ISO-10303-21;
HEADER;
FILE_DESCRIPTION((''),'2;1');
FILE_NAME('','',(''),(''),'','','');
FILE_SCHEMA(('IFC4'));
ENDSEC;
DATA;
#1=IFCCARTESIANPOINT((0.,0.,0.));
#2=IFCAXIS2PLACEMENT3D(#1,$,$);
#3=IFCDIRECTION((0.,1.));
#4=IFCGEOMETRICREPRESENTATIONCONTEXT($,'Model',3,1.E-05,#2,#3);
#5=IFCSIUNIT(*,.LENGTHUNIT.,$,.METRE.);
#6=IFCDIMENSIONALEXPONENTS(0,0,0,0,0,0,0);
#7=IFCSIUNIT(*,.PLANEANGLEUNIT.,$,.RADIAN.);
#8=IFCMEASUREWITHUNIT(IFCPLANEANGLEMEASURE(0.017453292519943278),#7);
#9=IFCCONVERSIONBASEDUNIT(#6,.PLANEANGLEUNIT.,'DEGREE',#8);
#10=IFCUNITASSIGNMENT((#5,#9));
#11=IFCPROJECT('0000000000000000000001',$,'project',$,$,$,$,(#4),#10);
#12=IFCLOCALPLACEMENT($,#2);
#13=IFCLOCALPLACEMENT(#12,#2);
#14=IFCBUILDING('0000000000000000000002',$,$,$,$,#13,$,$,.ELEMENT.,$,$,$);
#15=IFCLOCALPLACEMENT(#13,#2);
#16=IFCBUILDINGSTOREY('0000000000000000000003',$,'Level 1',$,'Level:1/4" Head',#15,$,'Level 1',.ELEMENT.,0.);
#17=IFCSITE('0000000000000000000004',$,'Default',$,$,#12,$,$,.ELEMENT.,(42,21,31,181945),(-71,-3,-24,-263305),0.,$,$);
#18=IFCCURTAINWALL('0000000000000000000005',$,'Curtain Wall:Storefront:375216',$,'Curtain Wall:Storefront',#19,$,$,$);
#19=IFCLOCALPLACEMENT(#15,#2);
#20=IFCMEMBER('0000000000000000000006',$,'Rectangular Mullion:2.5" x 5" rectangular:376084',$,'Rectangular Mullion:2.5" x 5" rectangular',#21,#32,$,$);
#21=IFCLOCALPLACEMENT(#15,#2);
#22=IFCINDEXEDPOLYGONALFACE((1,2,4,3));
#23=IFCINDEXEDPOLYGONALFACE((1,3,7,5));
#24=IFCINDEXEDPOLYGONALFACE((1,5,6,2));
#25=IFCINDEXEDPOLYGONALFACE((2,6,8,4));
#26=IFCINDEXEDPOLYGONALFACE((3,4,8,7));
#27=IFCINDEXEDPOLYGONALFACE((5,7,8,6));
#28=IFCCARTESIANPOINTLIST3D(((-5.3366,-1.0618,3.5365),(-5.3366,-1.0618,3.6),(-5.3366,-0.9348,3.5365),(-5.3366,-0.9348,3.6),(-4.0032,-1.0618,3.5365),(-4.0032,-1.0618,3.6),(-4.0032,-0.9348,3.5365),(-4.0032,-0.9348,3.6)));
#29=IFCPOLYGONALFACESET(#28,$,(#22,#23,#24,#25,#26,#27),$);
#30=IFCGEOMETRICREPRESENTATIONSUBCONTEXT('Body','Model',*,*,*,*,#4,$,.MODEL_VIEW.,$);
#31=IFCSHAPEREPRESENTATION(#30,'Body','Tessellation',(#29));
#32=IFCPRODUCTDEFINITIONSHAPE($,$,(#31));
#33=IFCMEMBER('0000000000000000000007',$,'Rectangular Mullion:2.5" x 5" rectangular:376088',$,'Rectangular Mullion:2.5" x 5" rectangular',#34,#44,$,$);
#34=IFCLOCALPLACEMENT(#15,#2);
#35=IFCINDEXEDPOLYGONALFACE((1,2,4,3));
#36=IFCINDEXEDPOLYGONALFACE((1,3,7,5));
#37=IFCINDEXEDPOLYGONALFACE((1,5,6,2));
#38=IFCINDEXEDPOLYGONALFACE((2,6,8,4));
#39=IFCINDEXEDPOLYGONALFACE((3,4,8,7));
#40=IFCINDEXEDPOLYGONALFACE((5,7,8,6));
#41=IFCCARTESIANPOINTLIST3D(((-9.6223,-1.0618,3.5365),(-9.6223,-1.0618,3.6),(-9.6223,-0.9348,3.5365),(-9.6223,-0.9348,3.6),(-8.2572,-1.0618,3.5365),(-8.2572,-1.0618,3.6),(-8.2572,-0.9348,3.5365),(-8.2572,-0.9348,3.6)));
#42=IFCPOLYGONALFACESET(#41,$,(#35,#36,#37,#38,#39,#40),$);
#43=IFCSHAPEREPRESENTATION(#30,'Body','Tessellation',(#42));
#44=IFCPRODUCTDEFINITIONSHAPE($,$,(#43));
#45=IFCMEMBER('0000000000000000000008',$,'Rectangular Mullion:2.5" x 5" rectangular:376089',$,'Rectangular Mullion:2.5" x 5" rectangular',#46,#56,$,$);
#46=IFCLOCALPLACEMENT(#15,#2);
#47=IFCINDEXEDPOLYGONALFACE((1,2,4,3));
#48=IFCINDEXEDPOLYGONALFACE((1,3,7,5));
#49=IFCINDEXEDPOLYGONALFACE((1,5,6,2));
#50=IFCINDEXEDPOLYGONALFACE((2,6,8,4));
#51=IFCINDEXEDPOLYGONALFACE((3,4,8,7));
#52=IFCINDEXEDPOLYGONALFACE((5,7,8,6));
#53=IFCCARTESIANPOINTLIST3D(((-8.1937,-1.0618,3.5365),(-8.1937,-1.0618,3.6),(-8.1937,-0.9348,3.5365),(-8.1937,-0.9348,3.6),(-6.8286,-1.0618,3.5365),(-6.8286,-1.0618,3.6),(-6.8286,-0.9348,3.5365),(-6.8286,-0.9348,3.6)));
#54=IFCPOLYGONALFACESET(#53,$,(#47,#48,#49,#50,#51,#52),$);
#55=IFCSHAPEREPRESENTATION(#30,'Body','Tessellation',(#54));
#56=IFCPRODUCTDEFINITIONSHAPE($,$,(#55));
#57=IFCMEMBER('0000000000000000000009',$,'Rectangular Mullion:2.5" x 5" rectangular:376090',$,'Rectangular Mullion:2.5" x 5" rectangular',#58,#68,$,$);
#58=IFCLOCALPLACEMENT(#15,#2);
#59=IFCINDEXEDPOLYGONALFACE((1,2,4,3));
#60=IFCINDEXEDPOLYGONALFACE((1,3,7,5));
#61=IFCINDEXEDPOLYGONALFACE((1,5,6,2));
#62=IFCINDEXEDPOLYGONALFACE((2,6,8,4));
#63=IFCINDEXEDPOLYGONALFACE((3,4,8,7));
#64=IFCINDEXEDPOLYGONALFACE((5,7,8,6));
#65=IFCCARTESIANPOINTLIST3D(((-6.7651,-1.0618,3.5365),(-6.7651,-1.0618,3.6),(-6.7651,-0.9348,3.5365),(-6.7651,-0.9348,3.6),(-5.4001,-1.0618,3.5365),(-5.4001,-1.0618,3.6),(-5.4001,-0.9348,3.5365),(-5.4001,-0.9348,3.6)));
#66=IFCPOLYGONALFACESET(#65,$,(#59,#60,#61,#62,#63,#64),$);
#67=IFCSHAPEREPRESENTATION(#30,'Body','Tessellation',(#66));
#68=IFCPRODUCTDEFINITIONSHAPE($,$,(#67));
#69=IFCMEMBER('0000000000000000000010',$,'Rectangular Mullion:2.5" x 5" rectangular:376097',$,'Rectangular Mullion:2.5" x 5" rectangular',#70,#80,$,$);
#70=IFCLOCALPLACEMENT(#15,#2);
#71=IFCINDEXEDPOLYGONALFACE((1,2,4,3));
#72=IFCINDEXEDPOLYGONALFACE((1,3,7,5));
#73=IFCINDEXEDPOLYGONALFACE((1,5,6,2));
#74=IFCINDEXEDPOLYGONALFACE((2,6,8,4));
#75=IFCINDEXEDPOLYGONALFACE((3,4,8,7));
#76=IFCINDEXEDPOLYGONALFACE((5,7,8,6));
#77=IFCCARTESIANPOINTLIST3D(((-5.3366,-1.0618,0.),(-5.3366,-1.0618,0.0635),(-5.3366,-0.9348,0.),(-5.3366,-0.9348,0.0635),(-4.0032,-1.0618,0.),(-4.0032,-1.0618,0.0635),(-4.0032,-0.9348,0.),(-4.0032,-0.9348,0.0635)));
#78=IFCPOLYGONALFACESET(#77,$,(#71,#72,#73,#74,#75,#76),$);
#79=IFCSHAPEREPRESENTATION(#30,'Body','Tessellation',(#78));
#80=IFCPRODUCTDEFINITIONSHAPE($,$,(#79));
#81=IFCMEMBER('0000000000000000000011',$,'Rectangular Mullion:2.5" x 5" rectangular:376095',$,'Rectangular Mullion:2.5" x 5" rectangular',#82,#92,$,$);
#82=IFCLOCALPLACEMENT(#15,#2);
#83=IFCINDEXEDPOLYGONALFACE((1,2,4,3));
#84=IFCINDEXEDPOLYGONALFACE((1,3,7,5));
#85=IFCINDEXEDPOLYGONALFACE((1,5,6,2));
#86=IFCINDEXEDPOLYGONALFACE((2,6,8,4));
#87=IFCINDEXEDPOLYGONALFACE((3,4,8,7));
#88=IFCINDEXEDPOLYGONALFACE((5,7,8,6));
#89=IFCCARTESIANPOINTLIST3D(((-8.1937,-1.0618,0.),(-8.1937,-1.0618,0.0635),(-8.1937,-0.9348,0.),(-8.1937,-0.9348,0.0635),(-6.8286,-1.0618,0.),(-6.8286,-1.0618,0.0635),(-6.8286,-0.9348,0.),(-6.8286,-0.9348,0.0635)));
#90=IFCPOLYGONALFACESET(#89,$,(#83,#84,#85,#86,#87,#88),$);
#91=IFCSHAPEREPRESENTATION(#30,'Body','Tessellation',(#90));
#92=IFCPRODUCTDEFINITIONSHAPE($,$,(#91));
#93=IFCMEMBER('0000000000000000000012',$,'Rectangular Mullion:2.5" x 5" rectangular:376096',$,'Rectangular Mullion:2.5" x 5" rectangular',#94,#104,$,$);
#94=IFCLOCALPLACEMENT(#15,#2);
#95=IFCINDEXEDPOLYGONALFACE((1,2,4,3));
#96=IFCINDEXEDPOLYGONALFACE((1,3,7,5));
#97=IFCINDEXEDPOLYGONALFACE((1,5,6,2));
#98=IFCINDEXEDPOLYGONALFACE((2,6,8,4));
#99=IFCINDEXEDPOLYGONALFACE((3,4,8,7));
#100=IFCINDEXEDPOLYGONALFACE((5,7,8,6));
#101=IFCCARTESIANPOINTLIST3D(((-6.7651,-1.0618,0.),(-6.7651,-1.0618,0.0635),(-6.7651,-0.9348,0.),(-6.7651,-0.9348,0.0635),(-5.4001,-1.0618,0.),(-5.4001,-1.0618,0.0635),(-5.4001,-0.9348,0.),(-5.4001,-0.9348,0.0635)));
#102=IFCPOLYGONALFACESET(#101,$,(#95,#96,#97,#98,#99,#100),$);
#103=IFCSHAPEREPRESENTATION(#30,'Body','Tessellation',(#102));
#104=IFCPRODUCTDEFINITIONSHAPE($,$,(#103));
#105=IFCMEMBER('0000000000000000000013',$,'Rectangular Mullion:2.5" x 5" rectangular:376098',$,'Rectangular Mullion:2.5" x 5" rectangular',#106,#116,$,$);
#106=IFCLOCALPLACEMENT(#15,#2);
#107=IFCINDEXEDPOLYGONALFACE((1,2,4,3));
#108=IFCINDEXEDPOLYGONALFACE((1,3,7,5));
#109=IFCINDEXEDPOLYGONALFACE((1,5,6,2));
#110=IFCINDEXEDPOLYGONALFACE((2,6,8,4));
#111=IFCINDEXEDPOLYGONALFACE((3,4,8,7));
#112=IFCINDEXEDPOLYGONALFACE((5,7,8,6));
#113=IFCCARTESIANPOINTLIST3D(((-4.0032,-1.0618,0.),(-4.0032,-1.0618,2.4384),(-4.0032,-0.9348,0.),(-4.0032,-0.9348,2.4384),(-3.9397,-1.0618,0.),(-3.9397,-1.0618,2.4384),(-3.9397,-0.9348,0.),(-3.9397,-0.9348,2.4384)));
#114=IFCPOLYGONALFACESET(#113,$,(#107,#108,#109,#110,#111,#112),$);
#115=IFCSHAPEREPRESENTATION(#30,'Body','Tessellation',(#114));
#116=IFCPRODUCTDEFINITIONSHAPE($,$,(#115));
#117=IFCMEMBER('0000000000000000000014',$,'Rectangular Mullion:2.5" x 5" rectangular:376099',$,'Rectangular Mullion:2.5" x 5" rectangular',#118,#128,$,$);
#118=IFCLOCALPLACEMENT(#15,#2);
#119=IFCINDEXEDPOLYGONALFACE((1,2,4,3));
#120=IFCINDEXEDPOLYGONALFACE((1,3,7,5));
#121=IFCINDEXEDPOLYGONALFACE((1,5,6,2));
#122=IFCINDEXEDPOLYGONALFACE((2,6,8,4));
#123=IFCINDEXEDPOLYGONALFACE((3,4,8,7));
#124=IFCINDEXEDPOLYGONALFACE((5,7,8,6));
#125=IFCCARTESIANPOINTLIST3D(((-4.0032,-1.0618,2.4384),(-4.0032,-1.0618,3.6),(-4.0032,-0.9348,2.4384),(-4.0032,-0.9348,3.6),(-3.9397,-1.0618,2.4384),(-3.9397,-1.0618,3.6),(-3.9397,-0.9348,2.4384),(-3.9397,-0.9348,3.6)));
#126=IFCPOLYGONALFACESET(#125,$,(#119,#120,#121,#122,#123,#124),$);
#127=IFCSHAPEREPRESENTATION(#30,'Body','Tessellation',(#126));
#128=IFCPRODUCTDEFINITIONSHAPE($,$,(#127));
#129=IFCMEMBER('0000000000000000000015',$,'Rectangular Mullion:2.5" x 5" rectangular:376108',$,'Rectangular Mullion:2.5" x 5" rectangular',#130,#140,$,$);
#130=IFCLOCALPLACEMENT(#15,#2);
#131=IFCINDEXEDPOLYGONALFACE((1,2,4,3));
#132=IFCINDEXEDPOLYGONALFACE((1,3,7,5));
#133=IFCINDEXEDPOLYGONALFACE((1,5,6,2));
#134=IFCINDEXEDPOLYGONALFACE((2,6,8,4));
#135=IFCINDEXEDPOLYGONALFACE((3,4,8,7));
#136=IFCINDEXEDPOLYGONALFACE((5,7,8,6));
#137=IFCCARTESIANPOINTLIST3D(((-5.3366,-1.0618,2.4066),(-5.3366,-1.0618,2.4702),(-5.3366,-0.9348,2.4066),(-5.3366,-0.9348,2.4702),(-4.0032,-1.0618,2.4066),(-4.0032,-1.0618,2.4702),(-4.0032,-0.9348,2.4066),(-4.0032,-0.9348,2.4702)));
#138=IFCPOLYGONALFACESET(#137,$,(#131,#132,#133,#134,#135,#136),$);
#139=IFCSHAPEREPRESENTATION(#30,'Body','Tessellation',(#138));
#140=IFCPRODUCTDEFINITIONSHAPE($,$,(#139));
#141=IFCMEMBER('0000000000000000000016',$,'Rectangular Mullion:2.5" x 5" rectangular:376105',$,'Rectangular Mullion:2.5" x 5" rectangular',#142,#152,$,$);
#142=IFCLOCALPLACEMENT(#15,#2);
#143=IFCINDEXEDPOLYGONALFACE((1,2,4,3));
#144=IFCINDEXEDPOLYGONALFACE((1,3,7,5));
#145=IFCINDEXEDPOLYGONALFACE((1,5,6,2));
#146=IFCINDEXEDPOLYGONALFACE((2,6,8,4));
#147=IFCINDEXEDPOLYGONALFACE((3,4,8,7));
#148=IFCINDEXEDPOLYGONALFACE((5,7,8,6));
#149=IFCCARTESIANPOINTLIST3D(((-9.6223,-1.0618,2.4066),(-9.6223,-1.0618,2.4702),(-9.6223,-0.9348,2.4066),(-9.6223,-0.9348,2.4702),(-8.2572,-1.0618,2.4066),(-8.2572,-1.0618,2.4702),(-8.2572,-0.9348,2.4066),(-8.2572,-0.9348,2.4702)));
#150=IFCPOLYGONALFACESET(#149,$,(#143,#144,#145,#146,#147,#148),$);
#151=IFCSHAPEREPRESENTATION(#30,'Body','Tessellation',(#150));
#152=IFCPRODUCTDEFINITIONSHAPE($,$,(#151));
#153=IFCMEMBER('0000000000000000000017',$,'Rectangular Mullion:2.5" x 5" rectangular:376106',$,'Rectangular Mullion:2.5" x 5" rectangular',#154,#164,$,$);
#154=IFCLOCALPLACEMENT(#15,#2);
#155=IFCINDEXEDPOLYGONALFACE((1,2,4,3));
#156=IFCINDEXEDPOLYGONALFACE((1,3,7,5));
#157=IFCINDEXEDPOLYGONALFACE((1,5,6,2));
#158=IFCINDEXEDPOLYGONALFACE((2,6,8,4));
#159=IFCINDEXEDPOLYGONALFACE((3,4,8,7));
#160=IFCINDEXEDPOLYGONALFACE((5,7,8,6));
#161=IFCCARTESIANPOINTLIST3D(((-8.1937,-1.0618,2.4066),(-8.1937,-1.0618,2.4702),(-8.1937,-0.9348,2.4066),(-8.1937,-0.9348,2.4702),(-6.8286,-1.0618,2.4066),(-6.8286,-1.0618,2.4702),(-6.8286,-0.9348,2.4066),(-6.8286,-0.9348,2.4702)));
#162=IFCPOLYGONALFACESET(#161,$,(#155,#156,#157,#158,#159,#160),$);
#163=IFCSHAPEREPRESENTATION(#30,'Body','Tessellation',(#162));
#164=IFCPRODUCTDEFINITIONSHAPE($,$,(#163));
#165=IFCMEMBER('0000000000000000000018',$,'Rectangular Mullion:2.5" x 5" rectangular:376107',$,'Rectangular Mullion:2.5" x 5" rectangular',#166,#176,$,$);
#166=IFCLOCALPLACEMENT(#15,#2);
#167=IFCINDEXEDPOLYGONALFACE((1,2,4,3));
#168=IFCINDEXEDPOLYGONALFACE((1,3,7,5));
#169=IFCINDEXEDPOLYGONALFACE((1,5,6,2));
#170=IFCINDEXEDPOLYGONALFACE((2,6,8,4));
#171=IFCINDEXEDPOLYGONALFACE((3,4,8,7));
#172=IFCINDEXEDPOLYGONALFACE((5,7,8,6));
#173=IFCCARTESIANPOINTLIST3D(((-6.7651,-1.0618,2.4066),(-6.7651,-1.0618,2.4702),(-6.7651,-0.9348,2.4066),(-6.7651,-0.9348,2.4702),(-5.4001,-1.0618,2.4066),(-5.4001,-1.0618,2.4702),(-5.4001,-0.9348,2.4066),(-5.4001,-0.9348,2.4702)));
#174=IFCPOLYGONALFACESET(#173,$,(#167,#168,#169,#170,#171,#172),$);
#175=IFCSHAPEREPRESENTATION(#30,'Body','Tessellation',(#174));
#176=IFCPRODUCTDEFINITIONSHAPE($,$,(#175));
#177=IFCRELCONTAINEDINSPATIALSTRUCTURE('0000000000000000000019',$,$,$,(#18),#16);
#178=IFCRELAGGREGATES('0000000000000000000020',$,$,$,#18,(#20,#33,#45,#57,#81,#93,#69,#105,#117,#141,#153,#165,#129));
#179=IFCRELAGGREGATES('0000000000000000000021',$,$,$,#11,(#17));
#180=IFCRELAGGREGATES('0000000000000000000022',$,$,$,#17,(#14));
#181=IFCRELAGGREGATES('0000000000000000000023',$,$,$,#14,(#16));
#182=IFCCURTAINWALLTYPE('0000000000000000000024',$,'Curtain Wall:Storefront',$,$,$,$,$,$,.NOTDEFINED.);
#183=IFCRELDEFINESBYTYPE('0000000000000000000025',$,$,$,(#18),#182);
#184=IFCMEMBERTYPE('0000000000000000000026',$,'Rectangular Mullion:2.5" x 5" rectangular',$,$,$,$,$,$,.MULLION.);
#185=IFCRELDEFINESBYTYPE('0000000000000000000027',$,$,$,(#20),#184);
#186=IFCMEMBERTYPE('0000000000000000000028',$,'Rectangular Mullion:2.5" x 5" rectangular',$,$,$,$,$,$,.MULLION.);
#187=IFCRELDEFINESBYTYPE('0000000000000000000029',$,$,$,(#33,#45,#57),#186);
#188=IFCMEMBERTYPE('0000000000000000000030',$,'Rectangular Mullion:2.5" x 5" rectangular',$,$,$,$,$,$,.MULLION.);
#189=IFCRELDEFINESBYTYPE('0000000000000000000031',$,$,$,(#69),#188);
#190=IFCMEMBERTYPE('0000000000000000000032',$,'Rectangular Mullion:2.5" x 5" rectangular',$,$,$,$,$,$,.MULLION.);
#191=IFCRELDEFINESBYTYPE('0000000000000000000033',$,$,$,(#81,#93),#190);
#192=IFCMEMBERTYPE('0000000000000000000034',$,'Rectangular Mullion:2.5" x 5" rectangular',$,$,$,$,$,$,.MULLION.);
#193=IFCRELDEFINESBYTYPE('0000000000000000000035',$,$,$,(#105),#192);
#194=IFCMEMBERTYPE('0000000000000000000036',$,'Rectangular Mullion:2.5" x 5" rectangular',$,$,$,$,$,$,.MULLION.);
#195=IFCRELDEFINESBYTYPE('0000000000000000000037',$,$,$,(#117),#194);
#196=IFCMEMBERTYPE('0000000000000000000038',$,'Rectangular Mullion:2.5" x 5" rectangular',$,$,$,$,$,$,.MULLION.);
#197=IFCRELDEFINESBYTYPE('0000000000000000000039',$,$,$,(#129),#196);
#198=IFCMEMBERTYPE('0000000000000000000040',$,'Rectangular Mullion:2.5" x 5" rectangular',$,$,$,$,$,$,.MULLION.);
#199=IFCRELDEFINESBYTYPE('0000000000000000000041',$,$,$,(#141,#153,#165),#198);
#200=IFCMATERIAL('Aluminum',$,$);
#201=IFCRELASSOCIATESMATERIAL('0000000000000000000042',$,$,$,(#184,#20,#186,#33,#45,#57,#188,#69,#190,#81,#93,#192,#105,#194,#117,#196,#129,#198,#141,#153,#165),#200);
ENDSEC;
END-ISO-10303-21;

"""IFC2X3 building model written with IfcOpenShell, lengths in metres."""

from ifc_helpers import new_model, entity, si_unit, converted_unit, direction, frame, frame_2d, origin, origin_2d_with_axis, place, context, subcontext, project, spatial, rectangle, extrude, source, transform, mapped, material, type_object, type_shapes, element, aggregate, save


model = new_model("IFC2X3")

# Units and contexts
model_context = context("Model", 3, precision=1e-05, world=origin(), true_north=direction((0.0, 1.0)))
body_context = subcontext(model_context, "Body", "Model", "MODEL_VIEW")
ifc_project = project(units=[si_unit("LENGTHUNIT", "METRE"), converted_unit("PLANEANGLEUNIT", "DEGREE", entity("IfcPlaneAngleMeasure", 0.017453292519943278), si_unit("PLANEANGLEUNIT", "RADIAN"), dimensions=[0, 0, 0, 0, 0, 0, 0])], contexts=[model_context])

# Site, building, storey
site_placement = place(None, origin())
site = spatial("IfcSite", under=ifc_project, at=site_placement, Name="Default", CompositionType="ELEMENT", RefLatitude=(42, 21, 31, 181945), RefLongitude=(-71, -3, -24, -263305), RefElevation=0.0)
building_placement = place(site_placement, origin())
building = spatial("IfcBuilding", under=site, at=building_placement, CompositionType="ELEMENT")
storey_placement = place(building_placement, origin())
storey = spatial("IfcBuildingStorey", under=building, at=storey_placement, Name="Level 1", ObjectType="Level:1/4\" Head", LongName="Level 1", CompositionType="ELEMENT", Elevation=0.0)

# Curtain wall, members
curtain_wall_type = type_object("IfcCurtainWallType", Name="Curtain Wall:Storefront", PredefinedType="NOTDEFINED")
curtain_wall_placement = place(storey_placement, origin())
curtain_wall = element("IfcCurtainWall", 1, at=curtain_wall_placement, inside=storey, type_object=curtain_wall_type, Name="Curtain Wall:Storefront:375216", ObjectType="Curtain Wall:Storefront")
ifc_material_1 = material(Name="Aluminum")
member_type_1 = type_object("IfcMemberType", Name="Rectangular Mullion:2.5\" x 5\" rectangular", PredefinedType="MULLION", material=ifc_material_1)
shared_shape_1 = source(origin(), body_context, "Body", "SweptSolid", [
    extrude(rectangle(XDim=0.0635, YDim=0.127, at=frame_2d((0.0, 0.0), x_axis=(1.0, 0.0))), frame((-0.0318, 0.0, -1.3333), z_axis=(0.0, 0.0, 1.0), x_axis=(-1.0, 0.0, 0.0)), (0.0, 0.0, 1.0), 1.3333),
])
type_shapes(member_type_1, [shared_shape_1])
member_1_placement = place(curtain_wall_placement, frame((-4.0032, -0.9983, 3.6), z_axis=(1.0, 0.0, 0.0), x_axis=(0.0, 0.0, 1.0)))
member_1 = element("IfcMember", 2, at=member_1_placement, type_object=member_type_1, material=ifc_material_1, Name="Rectangular Mullion:2.5\" x 5\" rectangular:376084", ObjectType="Rectangular Mullion:2.5\" x 5\" rectangular", context=body_context, shape_type="MappedRepresentation", body=[
    mapped(shared_shape_1, transform((0.0, 0.0, 0.0), scale=1.0)),
])
member_type_2 = type_object("IfcMemberType", Name="Rectangular Mullion:2.5\" x 5\" rectangular", PredefinedType="MULLION", material=ifc_material_1)
shared_shape_2 = source(origin(), body_context, "Body", "SweptSolid", [
    extrude(rectangle(XDim=0.0635, YDim=0.127, at=frame_2d((0.0, 0.0), x_axis=(1.0, 0.0))), frame((-0.0318, 0.0, -1.3651), z_axis=(0.0, 0.0, 1.0), x_axis=(-1.0, 0.0, 0.0)), (0.0, 0.0, 1.0), 1.3651),
])
type_shapes(member_type_2, [shared_shape_2])
member_2_placement = place(curtain_wall_placement, frame((-8.2572, -0.9983, 3.6), z_axis=(1.0, 0.0, 0.0), x_axis=(0.0, 0.0, 1.0)))
member_2 = element("IfcMember", 3, at=member_2_placement, type_object=member_type_2, material=ifc_material_1, Name="Rectangular Mullion:2.5\" x 5\" rectangular:376088", ObjectType="Rectangular Mullion:2.5\" x 5\" rectangular", context=body_context, shape_type="MappedRepresentation", body=[
    mapped(shared_shape_2, transform((0.0, 0.0, 0.0), scale=1.0)),
])
member_3_placement = place(curtain_wall_placement, frame((-6.8286, -0.9983, 3.6), z_axis=(1.0, 0.0, 0.0), x_axis=(0.0, 0.0, 1.0)))
member_3 = element("IfcMember", 4, at=member_3_placement, type_object=member_type_2, material=ifc_material_1, Name="Rectangular Mullion:2.5\" x 5\" rectangular:376089", ObjectType="Rectangular Mullion:2.5\" x 5\" rectangular", context=body_context, shape_type="MappedRepresentation", body=[
    mapped(shared_shape_2, transform((0.0, 0.0, 0.0), scale=1.0)),
])
member_4_placement = place(curtain_wall_placement, frame((-5.4001, -0.9983, 3.6), z_axis=(1.0, 0.0, 0.0), x_axis=(0.0, 0.0, 1.0)))
member_4 = element("IfcMember", 5, at=member_4_placement, type_object=member_type_2, material=ifc_material_1, Name="Rectangular Mullion:2.5\" x 5\" rectangular:376090", ObjectType="Rectangular Mullion:2.5\" x 5\" rectangular", context=body_context, shape_type="MappedRepresentation", body=[
    mapped(shared_shape_2, transform((0.0, 0.0, 0.0), scale=1.0)),
])
member_type_3 = type_object("IfcMemberType", Name="Rectangular Mullion:2.5\" x 5\" rectangular", PredefinedType="MULLION", material=ifc_material_1)
shared_shape_3 = source(origin(), body_context, "Body", "SweptSolid", [
    extrude(rectangle(XDim=0.0635, YDim=0.127, at=frame_2d((0.0, 0.0), x_axis=(1.0, 0.0))), frame((-0.0318, 0.0, -1.3333), z_axis=(0.0, 0.0, 1.0), x_axis=(-1.0, 0.0, 0.0)), (0.0, 0.0, 1.0), 1.3333),
])
type_shapes(member_type_3, [shared_shape_3])
member_5_placement = place(curtain_wall_placement, frame((-5.3366, -0.9983, 0.0), z_axis=(-1.0, 0.0, 0.0), x_axis=(0.0, 0.0, -1.0)))
member_5 = element("IfcMember", 6, at=member_5_placement, type_object=member_type_3, material=ifc_material_1, Name="Rectangular Mullion:2.5\" x 5\" rectangular:376097", ObjectType="Rectangular Mullion:2.5\" x 5\" rectangular", context=body_context, shape_type="MappedRepresentation", body=[
    mapped(shared_shape_3, transform((0.0, 0.0, 0.0), scale=1.0)),
])
member_type_4 = type_object("IfcMemberType", Name="Rectangular Mullion:2.5\" x 5\" rectangular", PredefinedType="MULLION", material=ifc_material_1)
shared_shape_4 = source(origin(), body_context, "Body", "SweptSolid", [
    extrude(rectangle(XDim=0.0635, YDim=0.127, at=frame_2d((0.0, 0.0), x_axis=(1.0, 0.0))), frame((-0.0318, 0.0, -1.3651), z_axis=(0.0, 0.0, 1.0), x_axis=(-1.0, 0.0, 0.0)), (0.0, 0.0, 1.0), 1.3651),
])
type_shapes(member_type_4, [shared_shape_4])
member_6_placement = place(curtain_wall_placement, frame((-8.1937, -0.9983, 0.0), z_axis=(-1.0, 0.0, 0.0), x_axis=(0.0, 0.0, -1.0)))
member_6 = element("IfcMember", 7, at=member_6_placement, type_object=member_type_4, material=ifc_material_1, Name="Rectangular Mullion:2.5\" x 5\" rectangular:376095", ObjectType="Rectangular Mullion:2.5\" x 5\" rectangular", context=body_context, shape_type="MappedRepresentation", body=[
    mapped(shared_shape_4, transform((0.0, 0.0, 0.0), scale=1.0)),
])
member_7_placement = place(curtain_wall_placement, frame((-6.7651, -0.9983, 0.0), z_axis=(-1.0, 0.0, 0.0), x_axis=(0.0, 0.0, -1.0)))
member_7 = element("IfcMember", 8, at=member_7_placement, type_object=member_type_4, material=ifc_material_1, Name="Rectangular Mullion:2.5\" x 5\" rectangular:376096", ObjectType="Rectangular Mullion:2.5\" x 5\" rectangular", context=body_context, shape_type="MappedRepresentation", body=[
    mapped(shared_shape_4, transform((0.0, 0.0, 0.0), scale=1.0)),
])
member_type_5 = type_object("IfcMemberType", Name="Rectangular Mullion:2.5\" x 5\" rectangular", PredefinedType="MULLION", material=ifc_material_1)
shared_shape_5 = source(origin(), body_context, "Body", "SweptSolid", [
    extrude(rectangle(XDim=0.0635, YDim=0.127, at=origin_2d_with_axis()), frame((-0.0318, 0.0, -2.4384), z_axis=(0.0, 0.0, 1.0), x_axis=(-1.0, 0.0, 0.0)), (0.0, 0.0, 1.0), 2.4384),
])
type_shapes(member_type_5, [shared_shape_5])
member_8_placement = place(curtain_wall_placement, frame((-3.9397, -0.9983, 0.0), z_axis=(0.0, 0.0, -1.0), x_axis=(1.0, 0.0, 0.0)))
member_8 = element("IfcMember", 9, at=member_8_placement, type_object=member_type_5, material=ifc_material_1, Name="Rectangular Mullion:2.5\" x 5\" rectangular:376098", ObjectType="Rectangular Mullion:2.5\" x 5\" rectangular", context=body_context, shape_type="MappedRepresentation", body=[
    mapped(shared_shape_5, transform((0.0, 0.0, 0.0), scale=1.0)),
])
member_type_6 = type_object("IfcMemberType", Name="Rectangular Mullion:2.5\" x 5\" rectangular", PredefinedType="MULLION", material=ifc_material_1)
shared_shape_6 = source(origin(), body_context, "Body", "SweptSolid", [
    extrude(rectangle(XDim=0.0635, YDim=0.127, at=origin_2d_with_axis()), frame((-0.0318, 0.0, -1.1616), z_axis=(0.0, 0.0, 1.0), x_axis=(-1.0, 0.0, 0.0)), (0.0, 0.0, 1.0), 1.1616),
])
type_shapes(member_type_6, [shared_shape_6])
member_9_placement = place(curtain_wall_placement, frame((-3.9397, -0.9983, 2.4384), z_axis=(0.0, 0.0, -1.0), x_axis=(1.0, 0.0, 0.0)))
member_9 = element("IfcMember", 10, at=member_9_placement, type_object=member_type_6, material=ifc_material_1, Name="Rectangular Mullion:2.5\" x 5\" rectangular:376099", ObjectType="Rectangular Mullion:2.5\" x 5\" rectangular", context=body_context, shape_type="MappedRepresentation", body=[
    mapped(shared_shape_6, transform((0.0, 0.0, 0.0), scale=1.0)),
])
member_type_7 = type_object("IfcMemberType", Name="Rectangular Mullion:2.5\" x 5\" rectangular", PredefinedType="MULLION", material=ifc_material_1)
shared_shape_7 = source(origin(), body_context, "Body", "SweptSolid", [
    extrude(rectangle(XDim=0.0635, YDim=0.127, at=origin_2d_with_axis()), frame((0.0, 0.0, -1.3333), z_axis=(0.0, 0.0, 1.0), x_axis=(-1.0, 0.0, 0.0)), (0.0, 0.0, 1.0), 1.3333),
])
type_shapes(member_type_7, [shared_shape_7])
member_10_placement = place(curtain_wall_placement, frame((-4.0032, -0.9983, 2.4384), z_axis=(1.0, 0.0, 0.0), x_axis=(0.0, 0.0, 1.0)))
member_10 = element("IfcMember", 11, at=member_10_placement, type_object=member_type_7, material=ifc_material_1, Name="Rectangular Mullion:2.5\" x 5\" rectangular:376108", ObjectType="Rectangular Mullion:2.5\" x 5\" rectangular", context=body_context, shape_type="MappedRepresentation", body=[
    mapped(shared_shape_7, transform((0.0, 0.0, 0.0), scale=1.0)),
])
member_type_8 = type_object("IfcMemberType", Name="Rectangular Mullion:2.5\" x 5\" rectangular", PredefinedType="MULLION", material=ifc_material_1)
shared_shape_8 = source(origin(), body_context, "Body", "SweptSolid", [
    extrude(rectangle(XDim=0.0635, YDim=0.127, at=origin_2d_with_axis()), frame((0.0, 0.0, -1.3651), z_axis=(0.0, 0.0, 1.0), x_axis=(-1.0, 0.0, 0.0)), (0.0, 0.0, 1.0), 1.3651),
])
type_shapes(member_type_8, [shared_shape_8])
member_11_placement = place(curtain_wall_placement, frame((-8.2572, -0.9983, 2.4384), z_axis=(1.0, 0.0, 0.0), x_axis=(0.0, 0.0, 1.0)))
member_11 = element("IfcMember", 12, at=member_11_placement, type_object=member_type_8, material=ifc_material_1, Name="Rectangular Mullion:2.5\" x 5\" rectangular:376105", ObjectType="Rectangular Mullion:2.5\" x 5\" rectangular", context=body_context, shape_type="MappedRepresentation", body=[
    mapped(shared_shape_8, transform((0.0, 0.0, 0.0), scale=1.0)),
])
member_12_placement = place(curtain_wall_placement, frame((-6.8286, -0.9983, 2.4384), z_axis=(1.0, 0.0, 0.0), x_axis=(0.0, 0.0, 1.0)))
member_12 = element("IfcMember", 13, at=member_12_placement, type_object=member_type_8, material=ifc_material_1, Name="Rectangular Mullion:2.5\" x 5\" rectangular:376106", ObjectType="Rectangular Mullion:2.5\" x 5\" rectangular", context=body_context, shape_type="MappedRepresentation", body=[
    mapped(shared_shape_8, transform((0.0, 0.0, 0.0), scale=1.0)),
])
member_13_placement = place(curtain_wall_placement, frame((-5.4001, -0.9983, 2.4384), z_axis=(1.0, 0.0, 0.0), x_axis=(0.0, 0.0, 1.0)))
member_13 = element("IfcMember", 14, at=member_13_placement, type_object=member_type_8, material=ifc_material_1, Name="Rectangular Mullion:2.5\" x 5\" rectangular:376107", ObjectType="Rectangular Mullion:2.5\" x 5\" rectangular", context=body_context, shape_type="MappedRepresentation", body=[
    mapped(shared_shape_8, transform((0.0, 0.0, 0.0), scale=1.0)),
])
aggregate(curtain_wall, [member_1, member_2, member_3, member_4, member_6, member_7, member_5, member_8, member_9, member_11, member_12, member_13, member_10])

save(model, "model.ifc")
